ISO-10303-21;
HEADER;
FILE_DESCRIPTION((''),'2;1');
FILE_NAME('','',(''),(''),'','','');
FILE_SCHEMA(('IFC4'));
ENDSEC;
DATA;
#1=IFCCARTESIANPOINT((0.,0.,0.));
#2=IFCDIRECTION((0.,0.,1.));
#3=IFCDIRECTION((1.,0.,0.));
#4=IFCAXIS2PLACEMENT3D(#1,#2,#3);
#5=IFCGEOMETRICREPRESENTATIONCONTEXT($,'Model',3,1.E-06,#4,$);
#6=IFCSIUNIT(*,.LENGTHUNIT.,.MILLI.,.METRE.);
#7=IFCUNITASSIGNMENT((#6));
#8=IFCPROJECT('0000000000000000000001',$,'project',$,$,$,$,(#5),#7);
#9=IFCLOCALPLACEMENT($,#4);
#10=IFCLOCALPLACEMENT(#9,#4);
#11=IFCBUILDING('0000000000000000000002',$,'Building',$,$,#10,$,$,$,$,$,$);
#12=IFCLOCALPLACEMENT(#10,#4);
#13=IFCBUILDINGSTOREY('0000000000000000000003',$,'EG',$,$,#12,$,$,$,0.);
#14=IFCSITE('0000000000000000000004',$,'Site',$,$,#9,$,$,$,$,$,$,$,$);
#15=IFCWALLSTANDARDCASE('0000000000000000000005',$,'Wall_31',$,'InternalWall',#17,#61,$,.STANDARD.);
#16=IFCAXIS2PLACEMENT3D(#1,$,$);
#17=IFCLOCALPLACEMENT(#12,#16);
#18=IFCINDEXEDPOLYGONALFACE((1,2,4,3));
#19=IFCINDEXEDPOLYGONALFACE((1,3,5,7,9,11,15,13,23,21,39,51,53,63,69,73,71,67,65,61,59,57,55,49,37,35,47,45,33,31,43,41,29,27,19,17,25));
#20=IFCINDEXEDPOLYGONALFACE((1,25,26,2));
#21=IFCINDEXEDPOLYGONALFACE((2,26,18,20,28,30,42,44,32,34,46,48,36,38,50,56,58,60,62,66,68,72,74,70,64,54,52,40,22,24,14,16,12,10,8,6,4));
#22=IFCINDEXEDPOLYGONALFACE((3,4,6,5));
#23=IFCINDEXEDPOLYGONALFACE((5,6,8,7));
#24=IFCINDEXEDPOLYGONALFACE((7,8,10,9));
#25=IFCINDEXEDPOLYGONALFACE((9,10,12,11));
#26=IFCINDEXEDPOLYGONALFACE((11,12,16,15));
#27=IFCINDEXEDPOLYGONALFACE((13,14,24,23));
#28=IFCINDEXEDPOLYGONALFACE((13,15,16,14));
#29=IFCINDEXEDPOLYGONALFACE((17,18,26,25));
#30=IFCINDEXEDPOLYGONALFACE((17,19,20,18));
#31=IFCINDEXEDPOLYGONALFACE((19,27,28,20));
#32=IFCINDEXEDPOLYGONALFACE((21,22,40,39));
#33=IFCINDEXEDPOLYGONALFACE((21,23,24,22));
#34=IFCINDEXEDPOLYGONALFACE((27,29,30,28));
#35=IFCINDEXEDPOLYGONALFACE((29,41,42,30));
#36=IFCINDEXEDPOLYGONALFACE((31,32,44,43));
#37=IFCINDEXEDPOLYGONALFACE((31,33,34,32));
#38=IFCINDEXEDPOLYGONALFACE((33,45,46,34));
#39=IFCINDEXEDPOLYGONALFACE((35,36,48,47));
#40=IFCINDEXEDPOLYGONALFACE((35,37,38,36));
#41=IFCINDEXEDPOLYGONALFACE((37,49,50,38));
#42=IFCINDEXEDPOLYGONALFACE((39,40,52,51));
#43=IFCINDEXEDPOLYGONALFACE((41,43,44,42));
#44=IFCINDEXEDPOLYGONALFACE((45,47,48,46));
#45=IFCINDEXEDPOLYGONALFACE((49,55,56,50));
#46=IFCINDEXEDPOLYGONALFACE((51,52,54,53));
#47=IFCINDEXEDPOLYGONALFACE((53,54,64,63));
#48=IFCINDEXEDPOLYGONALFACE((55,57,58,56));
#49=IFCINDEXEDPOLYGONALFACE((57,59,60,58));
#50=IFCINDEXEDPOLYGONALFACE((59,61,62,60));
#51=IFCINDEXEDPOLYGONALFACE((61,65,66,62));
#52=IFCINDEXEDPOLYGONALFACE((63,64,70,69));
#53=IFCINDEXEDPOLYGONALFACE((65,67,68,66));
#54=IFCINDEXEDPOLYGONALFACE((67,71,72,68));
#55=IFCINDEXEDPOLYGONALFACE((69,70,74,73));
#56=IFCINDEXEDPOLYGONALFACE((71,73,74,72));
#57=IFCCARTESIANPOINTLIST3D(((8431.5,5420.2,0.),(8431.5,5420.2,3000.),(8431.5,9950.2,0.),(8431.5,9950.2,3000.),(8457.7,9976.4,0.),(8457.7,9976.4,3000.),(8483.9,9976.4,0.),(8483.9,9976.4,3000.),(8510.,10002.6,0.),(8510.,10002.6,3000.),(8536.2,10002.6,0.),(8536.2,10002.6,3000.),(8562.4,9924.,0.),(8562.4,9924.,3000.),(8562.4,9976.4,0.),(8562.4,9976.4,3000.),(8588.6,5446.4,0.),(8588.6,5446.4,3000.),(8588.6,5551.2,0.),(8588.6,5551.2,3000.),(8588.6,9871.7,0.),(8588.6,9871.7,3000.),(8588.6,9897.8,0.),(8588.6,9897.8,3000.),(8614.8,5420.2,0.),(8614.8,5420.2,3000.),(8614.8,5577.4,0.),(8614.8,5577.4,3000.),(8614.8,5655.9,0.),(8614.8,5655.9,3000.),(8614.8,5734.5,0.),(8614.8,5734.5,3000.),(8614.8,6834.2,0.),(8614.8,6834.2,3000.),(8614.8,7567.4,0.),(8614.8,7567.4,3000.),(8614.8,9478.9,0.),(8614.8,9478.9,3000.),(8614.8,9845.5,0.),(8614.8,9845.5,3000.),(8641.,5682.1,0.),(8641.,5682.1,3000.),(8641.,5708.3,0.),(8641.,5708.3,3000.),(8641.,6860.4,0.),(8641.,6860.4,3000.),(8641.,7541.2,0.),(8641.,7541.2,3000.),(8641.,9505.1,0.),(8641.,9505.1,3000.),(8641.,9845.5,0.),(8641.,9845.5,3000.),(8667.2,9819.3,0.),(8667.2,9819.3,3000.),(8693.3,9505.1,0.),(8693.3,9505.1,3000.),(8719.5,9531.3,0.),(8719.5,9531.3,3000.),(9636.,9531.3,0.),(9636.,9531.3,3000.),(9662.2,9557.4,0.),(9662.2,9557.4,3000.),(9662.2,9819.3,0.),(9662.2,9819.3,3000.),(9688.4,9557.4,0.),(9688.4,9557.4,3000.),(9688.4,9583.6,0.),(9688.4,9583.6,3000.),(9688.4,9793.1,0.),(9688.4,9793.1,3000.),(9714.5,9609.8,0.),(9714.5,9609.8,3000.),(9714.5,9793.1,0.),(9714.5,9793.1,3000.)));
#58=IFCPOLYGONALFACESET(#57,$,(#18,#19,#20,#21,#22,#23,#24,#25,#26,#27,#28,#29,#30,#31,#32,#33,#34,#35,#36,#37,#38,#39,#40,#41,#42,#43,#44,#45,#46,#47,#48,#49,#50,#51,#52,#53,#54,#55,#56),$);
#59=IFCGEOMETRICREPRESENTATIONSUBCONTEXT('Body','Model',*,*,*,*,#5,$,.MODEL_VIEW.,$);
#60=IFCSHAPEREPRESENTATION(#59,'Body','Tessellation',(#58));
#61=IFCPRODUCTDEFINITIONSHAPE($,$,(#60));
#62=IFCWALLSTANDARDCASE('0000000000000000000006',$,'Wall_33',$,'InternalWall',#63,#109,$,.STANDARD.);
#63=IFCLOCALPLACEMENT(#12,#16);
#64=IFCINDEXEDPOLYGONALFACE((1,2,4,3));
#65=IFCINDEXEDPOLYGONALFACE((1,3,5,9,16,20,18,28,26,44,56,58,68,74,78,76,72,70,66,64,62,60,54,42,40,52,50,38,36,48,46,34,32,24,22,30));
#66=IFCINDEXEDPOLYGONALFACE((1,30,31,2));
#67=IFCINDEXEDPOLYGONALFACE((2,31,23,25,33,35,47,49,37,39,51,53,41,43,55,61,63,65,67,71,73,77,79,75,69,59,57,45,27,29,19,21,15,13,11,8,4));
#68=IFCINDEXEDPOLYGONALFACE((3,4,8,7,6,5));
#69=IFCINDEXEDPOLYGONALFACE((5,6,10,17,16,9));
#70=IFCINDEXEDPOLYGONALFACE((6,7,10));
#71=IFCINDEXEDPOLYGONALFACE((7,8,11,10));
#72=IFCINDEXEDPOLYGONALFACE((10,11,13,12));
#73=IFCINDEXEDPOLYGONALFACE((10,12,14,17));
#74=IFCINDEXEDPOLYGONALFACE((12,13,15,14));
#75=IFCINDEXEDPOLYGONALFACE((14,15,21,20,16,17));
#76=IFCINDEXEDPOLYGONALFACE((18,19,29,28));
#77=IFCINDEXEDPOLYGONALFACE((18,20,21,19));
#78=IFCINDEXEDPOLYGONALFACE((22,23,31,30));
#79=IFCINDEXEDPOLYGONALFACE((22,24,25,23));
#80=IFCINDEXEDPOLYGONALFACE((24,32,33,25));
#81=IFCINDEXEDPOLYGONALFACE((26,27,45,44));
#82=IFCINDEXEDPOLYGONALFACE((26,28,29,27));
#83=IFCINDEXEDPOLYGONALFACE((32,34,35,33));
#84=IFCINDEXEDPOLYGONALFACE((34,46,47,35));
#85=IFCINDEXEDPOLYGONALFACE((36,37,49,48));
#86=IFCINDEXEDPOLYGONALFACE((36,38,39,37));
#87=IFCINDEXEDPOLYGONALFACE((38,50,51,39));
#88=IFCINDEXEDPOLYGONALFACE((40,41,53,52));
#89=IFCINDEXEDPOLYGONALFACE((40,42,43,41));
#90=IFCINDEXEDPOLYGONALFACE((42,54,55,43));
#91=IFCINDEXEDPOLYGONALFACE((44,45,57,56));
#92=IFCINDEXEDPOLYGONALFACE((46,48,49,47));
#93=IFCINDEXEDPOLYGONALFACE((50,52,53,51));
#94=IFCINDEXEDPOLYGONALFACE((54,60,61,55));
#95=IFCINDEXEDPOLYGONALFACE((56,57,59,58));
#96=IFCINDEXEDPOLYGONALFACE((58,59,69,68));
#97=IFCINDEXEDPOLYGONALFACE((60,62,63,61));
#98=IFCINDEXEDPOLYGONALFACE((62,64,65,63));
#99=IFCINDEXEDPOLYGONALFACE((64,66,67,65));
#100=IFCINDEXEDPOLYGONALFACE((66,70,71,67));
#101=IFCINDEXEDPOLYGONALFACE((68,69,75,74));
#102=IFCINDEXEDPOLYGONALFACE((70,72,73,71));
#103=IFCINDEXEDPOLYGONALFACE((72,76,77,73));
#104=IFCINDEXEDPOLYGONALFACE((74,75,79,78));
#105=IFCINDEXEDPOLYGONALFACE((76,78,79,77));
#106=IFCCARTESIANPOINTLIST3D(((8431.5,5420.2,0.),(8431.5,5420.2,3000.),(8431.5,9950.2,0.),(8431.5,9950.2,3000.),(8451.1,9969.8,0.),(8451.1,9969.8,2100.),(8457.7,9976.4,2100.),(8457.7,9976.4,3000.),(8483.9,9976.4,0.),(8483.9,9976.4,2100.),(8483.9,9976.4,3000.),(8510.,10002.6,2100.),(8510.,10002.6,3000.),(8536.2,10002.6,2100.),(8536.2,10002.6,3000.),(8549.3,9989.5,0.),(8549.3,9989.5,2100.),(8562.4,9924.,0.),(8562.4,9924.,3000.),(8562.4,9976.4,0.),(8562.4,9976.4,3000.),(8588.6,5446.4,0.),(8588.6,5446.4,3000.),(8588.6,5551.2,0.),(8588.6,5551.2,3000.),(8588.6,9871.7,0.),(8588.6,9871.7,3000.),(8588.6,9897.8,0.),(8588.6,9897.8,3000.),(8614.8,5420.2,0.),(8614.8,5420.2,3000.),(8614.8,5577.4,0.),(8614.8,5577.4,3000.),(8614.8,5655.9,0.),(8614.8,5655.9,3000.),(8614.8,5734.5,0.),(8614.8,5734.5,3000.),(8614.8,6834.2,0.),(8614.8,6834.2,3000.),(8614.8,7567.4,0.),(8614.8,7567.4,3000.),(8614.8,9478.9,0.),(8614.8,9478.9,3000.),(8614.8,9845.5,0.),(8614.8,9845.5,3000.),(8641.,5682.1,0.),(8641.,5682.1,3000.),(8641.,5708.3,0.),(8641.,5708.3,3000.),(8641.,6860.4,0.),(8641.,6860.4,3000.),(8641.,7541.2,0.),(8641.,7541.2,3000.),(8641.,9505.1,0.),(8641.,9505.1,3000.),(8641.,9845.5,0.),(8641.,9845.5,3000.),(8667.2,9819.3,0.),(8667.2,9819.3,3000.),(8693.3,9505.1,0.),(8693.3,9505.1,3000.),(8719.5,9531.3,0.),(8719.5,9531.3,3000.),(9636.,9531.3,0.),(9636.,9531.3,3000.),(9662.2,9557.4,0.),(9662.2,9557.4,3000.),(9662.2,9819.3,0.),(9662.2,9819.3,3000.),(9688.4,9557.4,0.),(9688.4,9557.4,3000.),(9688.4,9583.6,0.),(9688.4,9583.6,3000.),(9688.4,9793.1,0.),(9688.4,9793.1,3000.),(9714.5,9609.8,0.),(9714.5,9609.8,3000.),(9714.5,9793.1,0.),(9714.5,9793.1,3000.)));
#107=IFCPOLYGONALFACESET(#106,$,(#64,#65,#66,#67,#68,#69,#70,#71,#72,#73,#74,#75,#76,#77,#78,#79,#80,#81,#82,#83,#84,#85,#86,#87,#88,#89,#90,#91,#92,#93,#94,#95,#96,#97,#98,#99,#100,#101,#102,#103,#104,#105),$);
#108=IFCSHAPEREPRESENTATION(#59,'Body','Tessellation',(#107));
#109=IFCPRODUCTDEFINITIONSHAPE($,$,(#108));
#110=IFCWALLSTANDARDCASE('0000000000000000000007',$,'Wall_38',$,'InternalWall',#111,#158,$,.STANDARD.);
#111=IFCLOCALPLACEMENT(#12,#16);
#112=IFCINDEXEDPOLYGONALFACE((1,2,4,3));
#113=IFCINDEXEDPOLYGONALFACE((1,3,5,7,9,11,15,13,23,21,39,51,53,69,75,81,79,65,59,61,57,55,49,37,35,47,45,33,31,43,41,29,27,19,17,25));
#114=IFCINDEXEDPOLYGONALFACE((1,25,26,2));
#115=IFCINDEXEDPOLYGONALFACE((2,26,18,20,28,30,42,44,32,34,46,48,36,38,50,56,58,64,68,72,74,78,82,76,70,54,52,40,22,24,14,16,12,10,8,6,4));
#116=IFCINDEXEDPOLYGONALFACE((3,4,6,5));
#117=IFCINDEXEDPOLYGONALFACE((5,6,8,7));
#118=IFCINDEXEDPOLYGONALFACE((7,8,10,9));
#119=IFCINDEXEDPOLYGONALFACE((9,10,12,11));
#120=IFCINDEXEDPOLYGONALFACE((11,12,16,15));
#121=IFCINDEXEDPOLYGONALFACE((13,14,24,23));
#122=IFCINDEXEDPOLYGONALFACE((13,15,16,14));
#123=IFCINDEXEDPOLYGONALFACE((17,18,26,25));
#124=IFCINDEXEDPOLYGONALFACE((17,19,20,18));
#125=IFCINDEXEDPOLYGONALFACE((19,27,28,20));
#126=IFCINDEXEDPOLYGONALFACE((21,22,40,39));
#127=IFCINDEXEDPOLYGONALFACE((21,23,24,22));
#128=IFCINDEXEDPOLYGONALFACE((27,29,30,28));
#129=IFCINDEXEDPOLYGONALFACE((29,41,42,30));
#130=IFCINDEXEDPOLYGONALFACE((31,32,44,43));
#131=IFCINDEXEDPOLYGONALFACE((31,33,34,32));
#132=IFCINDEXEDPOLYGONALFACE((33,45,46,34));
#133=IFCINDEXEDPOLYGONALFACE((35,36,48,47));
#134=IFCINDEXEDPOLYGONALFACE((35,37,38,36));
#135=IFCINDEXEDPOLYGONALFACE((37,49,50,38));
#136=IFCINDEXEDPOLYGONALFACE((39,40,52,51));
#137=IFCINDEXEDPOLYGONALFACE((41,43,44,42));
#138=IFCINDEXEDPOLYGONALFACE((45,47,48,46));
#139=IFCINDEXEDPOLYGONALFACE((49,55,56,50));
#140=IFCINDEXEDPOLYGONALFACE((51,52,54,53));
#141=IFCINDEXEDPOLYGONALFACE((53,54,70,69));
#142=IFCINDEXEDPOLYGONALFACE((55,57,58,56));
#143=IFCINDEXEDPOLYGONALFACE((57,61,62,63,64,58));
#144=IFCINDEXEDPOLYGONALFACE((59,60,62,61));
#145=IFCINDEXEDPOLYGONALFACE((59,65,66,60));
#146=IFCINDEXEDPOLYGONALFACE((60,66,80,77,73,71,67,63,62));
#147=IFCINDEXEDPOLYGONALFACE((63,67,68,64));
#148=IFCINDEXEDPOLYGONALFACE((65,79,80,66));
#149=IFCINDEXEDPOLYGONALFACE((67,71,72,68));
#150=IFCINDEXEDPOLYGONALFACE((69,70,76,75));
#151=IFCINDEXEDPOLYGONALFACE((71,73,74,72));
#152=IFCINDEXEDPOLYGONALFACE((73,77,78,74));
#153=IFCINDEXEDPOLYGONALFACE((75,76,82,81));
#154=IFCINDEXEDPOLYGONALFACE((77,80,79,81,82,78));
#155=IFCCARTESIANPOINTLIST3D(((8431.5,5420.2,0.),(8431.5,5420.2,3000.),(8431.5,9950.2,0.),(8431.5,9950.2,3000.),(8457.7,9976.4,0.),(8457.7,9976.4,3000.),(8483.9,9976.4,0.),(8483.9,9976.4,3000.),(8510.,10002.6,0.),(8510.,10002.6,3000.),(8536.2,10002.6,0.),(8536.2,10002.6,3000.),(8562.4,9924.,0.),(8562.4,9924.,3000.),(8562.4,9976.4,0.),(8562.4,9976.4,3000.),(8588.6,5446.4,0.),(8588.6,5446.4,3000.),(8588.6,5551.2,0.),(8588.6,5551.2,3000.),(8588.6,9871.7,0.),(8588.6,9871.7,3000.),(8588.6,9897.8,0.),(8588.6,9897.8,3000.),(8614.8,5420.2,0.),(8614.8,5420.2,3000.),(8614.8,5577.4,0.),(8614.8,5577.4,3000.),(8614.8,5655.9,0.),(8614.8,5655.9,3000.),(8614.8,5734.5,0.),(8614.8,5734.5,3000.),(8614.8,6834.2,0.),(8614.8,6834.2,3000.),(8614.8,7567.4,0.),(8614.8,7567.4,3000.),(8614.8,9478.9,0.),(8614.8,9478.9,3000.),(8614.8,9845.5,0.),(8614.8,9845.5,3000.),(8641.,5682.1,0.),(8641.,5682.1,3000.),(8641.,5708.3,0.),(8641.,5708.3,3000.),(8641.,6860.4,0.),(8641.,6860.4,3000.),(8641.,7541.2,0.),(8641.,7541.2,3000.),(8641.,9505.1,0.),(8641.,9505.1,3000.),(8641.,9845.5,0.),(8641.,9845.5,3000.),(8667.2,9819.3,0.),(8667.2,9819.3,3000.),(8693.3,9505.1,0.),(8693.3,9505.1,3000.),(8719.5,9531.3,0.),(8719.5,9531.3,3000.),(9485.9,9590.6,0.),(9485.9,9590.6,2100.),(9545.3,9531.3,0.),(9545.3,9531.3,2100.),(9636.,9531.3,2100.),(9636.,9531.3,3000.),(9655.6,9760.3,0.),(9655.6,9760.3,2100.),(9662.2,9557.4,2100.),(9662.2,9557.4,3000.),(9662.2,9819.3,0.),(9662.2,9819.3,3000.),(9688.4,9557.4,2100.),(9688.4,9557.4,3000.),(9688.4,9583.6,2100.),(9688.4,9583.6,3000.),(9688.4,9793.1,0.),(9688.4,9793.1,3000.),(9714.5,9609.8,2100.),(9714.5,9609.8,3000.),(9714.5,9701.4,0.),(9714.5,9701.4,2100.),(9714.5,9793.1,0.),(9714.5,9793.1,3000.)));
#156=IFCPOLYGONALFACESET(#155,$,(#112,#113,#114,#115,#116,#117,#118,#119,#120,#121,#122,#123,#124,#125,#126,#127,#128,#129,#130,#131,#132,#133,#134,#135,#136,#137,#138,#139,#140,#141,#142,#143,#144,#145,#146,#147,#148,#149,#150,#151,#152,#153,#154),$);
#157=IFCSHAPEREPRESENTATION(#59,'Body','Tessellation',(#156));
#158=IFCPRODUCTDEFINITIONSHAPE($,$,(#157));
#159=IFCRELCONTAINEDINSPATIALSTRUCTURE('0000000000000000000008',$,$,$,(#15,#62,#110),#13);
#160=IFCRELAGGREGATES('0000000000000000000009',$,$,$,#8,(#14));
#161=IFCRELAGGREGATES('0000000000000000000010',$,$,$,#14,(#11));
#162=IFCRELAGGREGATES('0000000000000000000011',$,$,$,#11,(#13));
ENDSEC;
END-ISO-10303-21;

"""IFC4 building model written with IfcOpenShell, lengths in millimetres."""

from ifc_helpers import new_model, si_unit, frame, origin_with_axes, place, context, subcontext, project, spatial, polyline, rectangle, outline, extrude, element, save


model = new_model("IFC4")

# Units and contexts
model_context = context("Model", 3, precision=1e-06, world=origin_with_axes())
body_context = subcontext(model_context, "Body", "Model", "MODEL_VIEW")
ifc_project = project(units=[si_unit("LENGTHUNIT", "METRE", prefix="MILLI")], contexts=[model_context])

# Site, building, storey
site_placement = place(None, origin_with_axes())
site = spatial("IfcSite", under=ifc_project, at=site_placement, Name="Site")
building_placement = place(site_placement, origin_with_axes())
building = spatial("IfcBuilding", under=site, at=building_placement, Name="Building")
storey_placement = place(building_placement, origin_with_axes())
storey = spatial("IfcBuildingStorey", under=building, at=storey_placement, Name="EG", Elevation=0.0)

# Wall
for number, where, z_axis, x_axis, name in (
    (1, (0.0, 0.0, 0.0), (0.0, 0.0, 1.0), (1.0, 0.0, 0.0), "Wall_31"),
):
    element("IfcWallStandardCase", number, at=place(storey_placement, frame(where, z_axis=z_axis, x_axis=x_axis)), inside=storey, Name=name, ObjectType="InternalWall", PredefinedType="STANDARD", context=body_context, shape_type="SweptSolid", body=[
        extrude(outline(polyline([(8431.5, 5420.2, 0.0), (8431.5, 9950.2, 0.0), (8457.7, 9976.4, 0.0), (8483.9, 9976.4, 0.0), (8510.0, 10002.6, 0.0), (8536.2, 10002.6, 0.0), (8562.4, 9976.4, 0.0), (8562.4, 9924.0, 0.0), (8588.6, 9897.8, 0.0), (8588.6, 9871.7, 0.0), (8614.8, 9845.5, 0.0), (8641.0, 9845.5, 0.0), (8667.2, 9819.3, 0.0), (9662.2, 9819.3, 0.0), (9688.4, 9793.1, 0.0), (9714.5, 9793.1, 0.0), (9714.5, 9609.8, 0.0), (9688.4, 9583.6, 0.0), (9688.4, 9557.4, 0.0), (9662.2, 9557.4, 0.0), (9636.0, 9531.3, 0.0), (8719.5, 9531.3, 0.0), (8693.3, 9505.1, 0.0), (8641.0, 9505.1, 0.0), (8614.8, 9478.9, 0.0), (8614.8, 7567.4, 0.0), (8641.0, 7541.2, 0.0), (8641.0, 6860.4, 0.0), (8614.8, 6834.2, 0.0), (8614.8, 5734.5, 0.0), (8641.0, 5708.3, 0.0), (8641.0, 5682.1, 0.0), (8614.8, 5655.9, 0.0), (8614.8, 5577.4, 0.0), (8588.6, 5551.2, 0.0), (8588.6, 5446.4, 0.0), (8614.8, 5420.2, 0.0), (8431.5, 5420.2, 0.0)])), origin_with_axes(), (0.0, 0.0, 1.0), 3000.0),
    ])

# Wall, opening
wall_1_placement = place(storey_placement, origin_with_axes())
wall_1 = element("IfcWallStandardCase", 2, at=wall_1_placement, inside=storey, Name="Wall_33", ObjectType="InternalWall", PredefinedType="STANDARD", context=body_context, shape_type="SweptSolid", body=[
    extrude(outline(polyline([(8431.5, 5420.2, 0.0), (8431.5, 9950.2, 0.0), (8457.7, 9976.4, 0.0), (8483.9, 9976.4, 0.0), (8510.0, 10002.6, 0.0), (8536.2, 10002.6, 0.0), (8562.4, 9976.4, 0.0), (8562.4, 9924.0, 0.0), (8588.6, 9897.8, 0.0), (8588.6, 9871.7, 0.0), (8614.8, 9845.5, 0.0), (8641.0, 9845.5, 0.0), (8667.2, 9819.3, 0.0), (9662.2, 9819.3, 0.0), (9688.4, 9793.1, 0.0), (9714.5, 9793.1, 0.0), (9714.5, 9609.8, 0.0), (9688.4, 9583.6, 0.0), (9688.4, 9557.4, 0.0), (9662.2, 9557.4, 0.0), (9636.0, 9531.3, 0.0), (8719.5, 9531.3, 0.0), (8693.3, 9505.1, 0.0), (8641.0, 9505.1, 0.0), (8614.8, 9478.9, 0.0), (8614.8, 7567.4, 0.0), (8641.0, 7541.2, 0.0), (8641.0, 6860.4, 0.0), (8614.8, 6834.2, 0.0), (8614.8, 5734.5, 0.0), (8641.0, 5708.3, 0.0), (8641.0, 5682.1, 0.0), (8614.8, 5655.9, 0.0), (8614.8, 5577.4, 0.0), (8588.6, 5551.2, 0.0), (8588.6, 5446.4, 0.0), (8614.8, 5420.2, 0.0), (8431.5, 5420.2, 0.0)])), origin_with_axes(), (0.0, 0.0, 1.0), 3000.0),
])
opening_1_placement = place(wall_1_placement, origin_with_axes())
element("IfcOpeningElement", 3, at=opening_1_placement, inside=storey, cuts=wall_1, context=body_context, shape_type="SweptSolid", body=[
    extrude(rectangle(XDim=1330.0, YDim=240.0), frame((8415.3, 10640.9, 0.0), z_axis=(0.0, 0.0, 1.0), x_axis=(-0.196116, 0.980581, 0.0)), (0.0, 0.0, 1.0), 2100.0),
])

# Wall, opening
wall_2_placement = place(storey_placement, origin_with_axes())
wall_2 = element("IfcWallStandardCase", 4, at=wall_2_placement, inside=storey, Name="Wall_38", ObjectType="InternalWall", PredefinedType="STANDARD", context=body_context, shape_type="SweptSolid", body=[
    extrude(outline(polyline([(8431.5, 5420.2, 0.0), (8431.5, 9950.2, 0.0), (8457.7, 9976.4, 0.0), (8483.9, 9976.4, 0.0), (8510.0, 10002.6, 0.0), (8536.2, 10002.6, 0.0), (8562.4, 9976.4, 0.0), (8562.4, 9924.0, 0.0), (8588.6, 9897.8, 0.0), (8588.6, 9871.7, 0.0), (8614.8, 9845.5, 0.0), (8641.0, 9845.5, 0.0), (8667.2, 9819.3, 0.0), (9662.2, 9819.3, 0.0), (9688.4, 9793.1, 0.0), (9714.5, 9793.1, 0.0), (9714.5, 9609.8, 0.0), (9688.4, 9583.6, 0.0), (9688.4, 9557.4, 0.0), (9662.2, 9557.4, 0.0), (9636.0, 9531.3, 0.0), (8719.5, 9531.3, 0.0), (8693.3, 9505.1, 0.0), (8641.0, 9505.1, 0.0), (8614.8, 9478.9, 0.0), (8614.8, 7567.4, 0.0), (8641.0, 7541.2, 0.0), (8641.0, 6860.4, 0.0), (8614.8, 6834.2, 0.0), (8614.8, 5734.5, 0.0), (8641.0, 5708.3, 0.0), (8641.0, 5682.1, 0.0), (8614.8, 5655.9, 0.0), (8614.8, 5577.4, 0.0), (8588.6, 5551.2, 0.0), (8588.6, 5446.4, 0.0), (8614.8, 5420.2, 0.0), (8431.5, 5420.2, 0.0)])), origin_with_axes(), (0.0, 0.0, 1.0), 3000.0),
])
opening_2_placement = place(wall_2_placement, origin_with_axes())
element("IfcOpeningElement", 5, at=opening_2_placement, inside=storey, cuts=wall_2, context=body_context, shape_type="SweptSolid", body=[
    extrude(rectangle(XDim=1333.1, YDim=240.0), frame((10042.1, 9204.2, 0.0), z_axis=(0.0, 0.0, 1.0), x_axis=(0.707107, -0.707107, 0.0)), (0.0, 0.0, 1.0), 2100.0),
])

save(model, "model.ifc")
